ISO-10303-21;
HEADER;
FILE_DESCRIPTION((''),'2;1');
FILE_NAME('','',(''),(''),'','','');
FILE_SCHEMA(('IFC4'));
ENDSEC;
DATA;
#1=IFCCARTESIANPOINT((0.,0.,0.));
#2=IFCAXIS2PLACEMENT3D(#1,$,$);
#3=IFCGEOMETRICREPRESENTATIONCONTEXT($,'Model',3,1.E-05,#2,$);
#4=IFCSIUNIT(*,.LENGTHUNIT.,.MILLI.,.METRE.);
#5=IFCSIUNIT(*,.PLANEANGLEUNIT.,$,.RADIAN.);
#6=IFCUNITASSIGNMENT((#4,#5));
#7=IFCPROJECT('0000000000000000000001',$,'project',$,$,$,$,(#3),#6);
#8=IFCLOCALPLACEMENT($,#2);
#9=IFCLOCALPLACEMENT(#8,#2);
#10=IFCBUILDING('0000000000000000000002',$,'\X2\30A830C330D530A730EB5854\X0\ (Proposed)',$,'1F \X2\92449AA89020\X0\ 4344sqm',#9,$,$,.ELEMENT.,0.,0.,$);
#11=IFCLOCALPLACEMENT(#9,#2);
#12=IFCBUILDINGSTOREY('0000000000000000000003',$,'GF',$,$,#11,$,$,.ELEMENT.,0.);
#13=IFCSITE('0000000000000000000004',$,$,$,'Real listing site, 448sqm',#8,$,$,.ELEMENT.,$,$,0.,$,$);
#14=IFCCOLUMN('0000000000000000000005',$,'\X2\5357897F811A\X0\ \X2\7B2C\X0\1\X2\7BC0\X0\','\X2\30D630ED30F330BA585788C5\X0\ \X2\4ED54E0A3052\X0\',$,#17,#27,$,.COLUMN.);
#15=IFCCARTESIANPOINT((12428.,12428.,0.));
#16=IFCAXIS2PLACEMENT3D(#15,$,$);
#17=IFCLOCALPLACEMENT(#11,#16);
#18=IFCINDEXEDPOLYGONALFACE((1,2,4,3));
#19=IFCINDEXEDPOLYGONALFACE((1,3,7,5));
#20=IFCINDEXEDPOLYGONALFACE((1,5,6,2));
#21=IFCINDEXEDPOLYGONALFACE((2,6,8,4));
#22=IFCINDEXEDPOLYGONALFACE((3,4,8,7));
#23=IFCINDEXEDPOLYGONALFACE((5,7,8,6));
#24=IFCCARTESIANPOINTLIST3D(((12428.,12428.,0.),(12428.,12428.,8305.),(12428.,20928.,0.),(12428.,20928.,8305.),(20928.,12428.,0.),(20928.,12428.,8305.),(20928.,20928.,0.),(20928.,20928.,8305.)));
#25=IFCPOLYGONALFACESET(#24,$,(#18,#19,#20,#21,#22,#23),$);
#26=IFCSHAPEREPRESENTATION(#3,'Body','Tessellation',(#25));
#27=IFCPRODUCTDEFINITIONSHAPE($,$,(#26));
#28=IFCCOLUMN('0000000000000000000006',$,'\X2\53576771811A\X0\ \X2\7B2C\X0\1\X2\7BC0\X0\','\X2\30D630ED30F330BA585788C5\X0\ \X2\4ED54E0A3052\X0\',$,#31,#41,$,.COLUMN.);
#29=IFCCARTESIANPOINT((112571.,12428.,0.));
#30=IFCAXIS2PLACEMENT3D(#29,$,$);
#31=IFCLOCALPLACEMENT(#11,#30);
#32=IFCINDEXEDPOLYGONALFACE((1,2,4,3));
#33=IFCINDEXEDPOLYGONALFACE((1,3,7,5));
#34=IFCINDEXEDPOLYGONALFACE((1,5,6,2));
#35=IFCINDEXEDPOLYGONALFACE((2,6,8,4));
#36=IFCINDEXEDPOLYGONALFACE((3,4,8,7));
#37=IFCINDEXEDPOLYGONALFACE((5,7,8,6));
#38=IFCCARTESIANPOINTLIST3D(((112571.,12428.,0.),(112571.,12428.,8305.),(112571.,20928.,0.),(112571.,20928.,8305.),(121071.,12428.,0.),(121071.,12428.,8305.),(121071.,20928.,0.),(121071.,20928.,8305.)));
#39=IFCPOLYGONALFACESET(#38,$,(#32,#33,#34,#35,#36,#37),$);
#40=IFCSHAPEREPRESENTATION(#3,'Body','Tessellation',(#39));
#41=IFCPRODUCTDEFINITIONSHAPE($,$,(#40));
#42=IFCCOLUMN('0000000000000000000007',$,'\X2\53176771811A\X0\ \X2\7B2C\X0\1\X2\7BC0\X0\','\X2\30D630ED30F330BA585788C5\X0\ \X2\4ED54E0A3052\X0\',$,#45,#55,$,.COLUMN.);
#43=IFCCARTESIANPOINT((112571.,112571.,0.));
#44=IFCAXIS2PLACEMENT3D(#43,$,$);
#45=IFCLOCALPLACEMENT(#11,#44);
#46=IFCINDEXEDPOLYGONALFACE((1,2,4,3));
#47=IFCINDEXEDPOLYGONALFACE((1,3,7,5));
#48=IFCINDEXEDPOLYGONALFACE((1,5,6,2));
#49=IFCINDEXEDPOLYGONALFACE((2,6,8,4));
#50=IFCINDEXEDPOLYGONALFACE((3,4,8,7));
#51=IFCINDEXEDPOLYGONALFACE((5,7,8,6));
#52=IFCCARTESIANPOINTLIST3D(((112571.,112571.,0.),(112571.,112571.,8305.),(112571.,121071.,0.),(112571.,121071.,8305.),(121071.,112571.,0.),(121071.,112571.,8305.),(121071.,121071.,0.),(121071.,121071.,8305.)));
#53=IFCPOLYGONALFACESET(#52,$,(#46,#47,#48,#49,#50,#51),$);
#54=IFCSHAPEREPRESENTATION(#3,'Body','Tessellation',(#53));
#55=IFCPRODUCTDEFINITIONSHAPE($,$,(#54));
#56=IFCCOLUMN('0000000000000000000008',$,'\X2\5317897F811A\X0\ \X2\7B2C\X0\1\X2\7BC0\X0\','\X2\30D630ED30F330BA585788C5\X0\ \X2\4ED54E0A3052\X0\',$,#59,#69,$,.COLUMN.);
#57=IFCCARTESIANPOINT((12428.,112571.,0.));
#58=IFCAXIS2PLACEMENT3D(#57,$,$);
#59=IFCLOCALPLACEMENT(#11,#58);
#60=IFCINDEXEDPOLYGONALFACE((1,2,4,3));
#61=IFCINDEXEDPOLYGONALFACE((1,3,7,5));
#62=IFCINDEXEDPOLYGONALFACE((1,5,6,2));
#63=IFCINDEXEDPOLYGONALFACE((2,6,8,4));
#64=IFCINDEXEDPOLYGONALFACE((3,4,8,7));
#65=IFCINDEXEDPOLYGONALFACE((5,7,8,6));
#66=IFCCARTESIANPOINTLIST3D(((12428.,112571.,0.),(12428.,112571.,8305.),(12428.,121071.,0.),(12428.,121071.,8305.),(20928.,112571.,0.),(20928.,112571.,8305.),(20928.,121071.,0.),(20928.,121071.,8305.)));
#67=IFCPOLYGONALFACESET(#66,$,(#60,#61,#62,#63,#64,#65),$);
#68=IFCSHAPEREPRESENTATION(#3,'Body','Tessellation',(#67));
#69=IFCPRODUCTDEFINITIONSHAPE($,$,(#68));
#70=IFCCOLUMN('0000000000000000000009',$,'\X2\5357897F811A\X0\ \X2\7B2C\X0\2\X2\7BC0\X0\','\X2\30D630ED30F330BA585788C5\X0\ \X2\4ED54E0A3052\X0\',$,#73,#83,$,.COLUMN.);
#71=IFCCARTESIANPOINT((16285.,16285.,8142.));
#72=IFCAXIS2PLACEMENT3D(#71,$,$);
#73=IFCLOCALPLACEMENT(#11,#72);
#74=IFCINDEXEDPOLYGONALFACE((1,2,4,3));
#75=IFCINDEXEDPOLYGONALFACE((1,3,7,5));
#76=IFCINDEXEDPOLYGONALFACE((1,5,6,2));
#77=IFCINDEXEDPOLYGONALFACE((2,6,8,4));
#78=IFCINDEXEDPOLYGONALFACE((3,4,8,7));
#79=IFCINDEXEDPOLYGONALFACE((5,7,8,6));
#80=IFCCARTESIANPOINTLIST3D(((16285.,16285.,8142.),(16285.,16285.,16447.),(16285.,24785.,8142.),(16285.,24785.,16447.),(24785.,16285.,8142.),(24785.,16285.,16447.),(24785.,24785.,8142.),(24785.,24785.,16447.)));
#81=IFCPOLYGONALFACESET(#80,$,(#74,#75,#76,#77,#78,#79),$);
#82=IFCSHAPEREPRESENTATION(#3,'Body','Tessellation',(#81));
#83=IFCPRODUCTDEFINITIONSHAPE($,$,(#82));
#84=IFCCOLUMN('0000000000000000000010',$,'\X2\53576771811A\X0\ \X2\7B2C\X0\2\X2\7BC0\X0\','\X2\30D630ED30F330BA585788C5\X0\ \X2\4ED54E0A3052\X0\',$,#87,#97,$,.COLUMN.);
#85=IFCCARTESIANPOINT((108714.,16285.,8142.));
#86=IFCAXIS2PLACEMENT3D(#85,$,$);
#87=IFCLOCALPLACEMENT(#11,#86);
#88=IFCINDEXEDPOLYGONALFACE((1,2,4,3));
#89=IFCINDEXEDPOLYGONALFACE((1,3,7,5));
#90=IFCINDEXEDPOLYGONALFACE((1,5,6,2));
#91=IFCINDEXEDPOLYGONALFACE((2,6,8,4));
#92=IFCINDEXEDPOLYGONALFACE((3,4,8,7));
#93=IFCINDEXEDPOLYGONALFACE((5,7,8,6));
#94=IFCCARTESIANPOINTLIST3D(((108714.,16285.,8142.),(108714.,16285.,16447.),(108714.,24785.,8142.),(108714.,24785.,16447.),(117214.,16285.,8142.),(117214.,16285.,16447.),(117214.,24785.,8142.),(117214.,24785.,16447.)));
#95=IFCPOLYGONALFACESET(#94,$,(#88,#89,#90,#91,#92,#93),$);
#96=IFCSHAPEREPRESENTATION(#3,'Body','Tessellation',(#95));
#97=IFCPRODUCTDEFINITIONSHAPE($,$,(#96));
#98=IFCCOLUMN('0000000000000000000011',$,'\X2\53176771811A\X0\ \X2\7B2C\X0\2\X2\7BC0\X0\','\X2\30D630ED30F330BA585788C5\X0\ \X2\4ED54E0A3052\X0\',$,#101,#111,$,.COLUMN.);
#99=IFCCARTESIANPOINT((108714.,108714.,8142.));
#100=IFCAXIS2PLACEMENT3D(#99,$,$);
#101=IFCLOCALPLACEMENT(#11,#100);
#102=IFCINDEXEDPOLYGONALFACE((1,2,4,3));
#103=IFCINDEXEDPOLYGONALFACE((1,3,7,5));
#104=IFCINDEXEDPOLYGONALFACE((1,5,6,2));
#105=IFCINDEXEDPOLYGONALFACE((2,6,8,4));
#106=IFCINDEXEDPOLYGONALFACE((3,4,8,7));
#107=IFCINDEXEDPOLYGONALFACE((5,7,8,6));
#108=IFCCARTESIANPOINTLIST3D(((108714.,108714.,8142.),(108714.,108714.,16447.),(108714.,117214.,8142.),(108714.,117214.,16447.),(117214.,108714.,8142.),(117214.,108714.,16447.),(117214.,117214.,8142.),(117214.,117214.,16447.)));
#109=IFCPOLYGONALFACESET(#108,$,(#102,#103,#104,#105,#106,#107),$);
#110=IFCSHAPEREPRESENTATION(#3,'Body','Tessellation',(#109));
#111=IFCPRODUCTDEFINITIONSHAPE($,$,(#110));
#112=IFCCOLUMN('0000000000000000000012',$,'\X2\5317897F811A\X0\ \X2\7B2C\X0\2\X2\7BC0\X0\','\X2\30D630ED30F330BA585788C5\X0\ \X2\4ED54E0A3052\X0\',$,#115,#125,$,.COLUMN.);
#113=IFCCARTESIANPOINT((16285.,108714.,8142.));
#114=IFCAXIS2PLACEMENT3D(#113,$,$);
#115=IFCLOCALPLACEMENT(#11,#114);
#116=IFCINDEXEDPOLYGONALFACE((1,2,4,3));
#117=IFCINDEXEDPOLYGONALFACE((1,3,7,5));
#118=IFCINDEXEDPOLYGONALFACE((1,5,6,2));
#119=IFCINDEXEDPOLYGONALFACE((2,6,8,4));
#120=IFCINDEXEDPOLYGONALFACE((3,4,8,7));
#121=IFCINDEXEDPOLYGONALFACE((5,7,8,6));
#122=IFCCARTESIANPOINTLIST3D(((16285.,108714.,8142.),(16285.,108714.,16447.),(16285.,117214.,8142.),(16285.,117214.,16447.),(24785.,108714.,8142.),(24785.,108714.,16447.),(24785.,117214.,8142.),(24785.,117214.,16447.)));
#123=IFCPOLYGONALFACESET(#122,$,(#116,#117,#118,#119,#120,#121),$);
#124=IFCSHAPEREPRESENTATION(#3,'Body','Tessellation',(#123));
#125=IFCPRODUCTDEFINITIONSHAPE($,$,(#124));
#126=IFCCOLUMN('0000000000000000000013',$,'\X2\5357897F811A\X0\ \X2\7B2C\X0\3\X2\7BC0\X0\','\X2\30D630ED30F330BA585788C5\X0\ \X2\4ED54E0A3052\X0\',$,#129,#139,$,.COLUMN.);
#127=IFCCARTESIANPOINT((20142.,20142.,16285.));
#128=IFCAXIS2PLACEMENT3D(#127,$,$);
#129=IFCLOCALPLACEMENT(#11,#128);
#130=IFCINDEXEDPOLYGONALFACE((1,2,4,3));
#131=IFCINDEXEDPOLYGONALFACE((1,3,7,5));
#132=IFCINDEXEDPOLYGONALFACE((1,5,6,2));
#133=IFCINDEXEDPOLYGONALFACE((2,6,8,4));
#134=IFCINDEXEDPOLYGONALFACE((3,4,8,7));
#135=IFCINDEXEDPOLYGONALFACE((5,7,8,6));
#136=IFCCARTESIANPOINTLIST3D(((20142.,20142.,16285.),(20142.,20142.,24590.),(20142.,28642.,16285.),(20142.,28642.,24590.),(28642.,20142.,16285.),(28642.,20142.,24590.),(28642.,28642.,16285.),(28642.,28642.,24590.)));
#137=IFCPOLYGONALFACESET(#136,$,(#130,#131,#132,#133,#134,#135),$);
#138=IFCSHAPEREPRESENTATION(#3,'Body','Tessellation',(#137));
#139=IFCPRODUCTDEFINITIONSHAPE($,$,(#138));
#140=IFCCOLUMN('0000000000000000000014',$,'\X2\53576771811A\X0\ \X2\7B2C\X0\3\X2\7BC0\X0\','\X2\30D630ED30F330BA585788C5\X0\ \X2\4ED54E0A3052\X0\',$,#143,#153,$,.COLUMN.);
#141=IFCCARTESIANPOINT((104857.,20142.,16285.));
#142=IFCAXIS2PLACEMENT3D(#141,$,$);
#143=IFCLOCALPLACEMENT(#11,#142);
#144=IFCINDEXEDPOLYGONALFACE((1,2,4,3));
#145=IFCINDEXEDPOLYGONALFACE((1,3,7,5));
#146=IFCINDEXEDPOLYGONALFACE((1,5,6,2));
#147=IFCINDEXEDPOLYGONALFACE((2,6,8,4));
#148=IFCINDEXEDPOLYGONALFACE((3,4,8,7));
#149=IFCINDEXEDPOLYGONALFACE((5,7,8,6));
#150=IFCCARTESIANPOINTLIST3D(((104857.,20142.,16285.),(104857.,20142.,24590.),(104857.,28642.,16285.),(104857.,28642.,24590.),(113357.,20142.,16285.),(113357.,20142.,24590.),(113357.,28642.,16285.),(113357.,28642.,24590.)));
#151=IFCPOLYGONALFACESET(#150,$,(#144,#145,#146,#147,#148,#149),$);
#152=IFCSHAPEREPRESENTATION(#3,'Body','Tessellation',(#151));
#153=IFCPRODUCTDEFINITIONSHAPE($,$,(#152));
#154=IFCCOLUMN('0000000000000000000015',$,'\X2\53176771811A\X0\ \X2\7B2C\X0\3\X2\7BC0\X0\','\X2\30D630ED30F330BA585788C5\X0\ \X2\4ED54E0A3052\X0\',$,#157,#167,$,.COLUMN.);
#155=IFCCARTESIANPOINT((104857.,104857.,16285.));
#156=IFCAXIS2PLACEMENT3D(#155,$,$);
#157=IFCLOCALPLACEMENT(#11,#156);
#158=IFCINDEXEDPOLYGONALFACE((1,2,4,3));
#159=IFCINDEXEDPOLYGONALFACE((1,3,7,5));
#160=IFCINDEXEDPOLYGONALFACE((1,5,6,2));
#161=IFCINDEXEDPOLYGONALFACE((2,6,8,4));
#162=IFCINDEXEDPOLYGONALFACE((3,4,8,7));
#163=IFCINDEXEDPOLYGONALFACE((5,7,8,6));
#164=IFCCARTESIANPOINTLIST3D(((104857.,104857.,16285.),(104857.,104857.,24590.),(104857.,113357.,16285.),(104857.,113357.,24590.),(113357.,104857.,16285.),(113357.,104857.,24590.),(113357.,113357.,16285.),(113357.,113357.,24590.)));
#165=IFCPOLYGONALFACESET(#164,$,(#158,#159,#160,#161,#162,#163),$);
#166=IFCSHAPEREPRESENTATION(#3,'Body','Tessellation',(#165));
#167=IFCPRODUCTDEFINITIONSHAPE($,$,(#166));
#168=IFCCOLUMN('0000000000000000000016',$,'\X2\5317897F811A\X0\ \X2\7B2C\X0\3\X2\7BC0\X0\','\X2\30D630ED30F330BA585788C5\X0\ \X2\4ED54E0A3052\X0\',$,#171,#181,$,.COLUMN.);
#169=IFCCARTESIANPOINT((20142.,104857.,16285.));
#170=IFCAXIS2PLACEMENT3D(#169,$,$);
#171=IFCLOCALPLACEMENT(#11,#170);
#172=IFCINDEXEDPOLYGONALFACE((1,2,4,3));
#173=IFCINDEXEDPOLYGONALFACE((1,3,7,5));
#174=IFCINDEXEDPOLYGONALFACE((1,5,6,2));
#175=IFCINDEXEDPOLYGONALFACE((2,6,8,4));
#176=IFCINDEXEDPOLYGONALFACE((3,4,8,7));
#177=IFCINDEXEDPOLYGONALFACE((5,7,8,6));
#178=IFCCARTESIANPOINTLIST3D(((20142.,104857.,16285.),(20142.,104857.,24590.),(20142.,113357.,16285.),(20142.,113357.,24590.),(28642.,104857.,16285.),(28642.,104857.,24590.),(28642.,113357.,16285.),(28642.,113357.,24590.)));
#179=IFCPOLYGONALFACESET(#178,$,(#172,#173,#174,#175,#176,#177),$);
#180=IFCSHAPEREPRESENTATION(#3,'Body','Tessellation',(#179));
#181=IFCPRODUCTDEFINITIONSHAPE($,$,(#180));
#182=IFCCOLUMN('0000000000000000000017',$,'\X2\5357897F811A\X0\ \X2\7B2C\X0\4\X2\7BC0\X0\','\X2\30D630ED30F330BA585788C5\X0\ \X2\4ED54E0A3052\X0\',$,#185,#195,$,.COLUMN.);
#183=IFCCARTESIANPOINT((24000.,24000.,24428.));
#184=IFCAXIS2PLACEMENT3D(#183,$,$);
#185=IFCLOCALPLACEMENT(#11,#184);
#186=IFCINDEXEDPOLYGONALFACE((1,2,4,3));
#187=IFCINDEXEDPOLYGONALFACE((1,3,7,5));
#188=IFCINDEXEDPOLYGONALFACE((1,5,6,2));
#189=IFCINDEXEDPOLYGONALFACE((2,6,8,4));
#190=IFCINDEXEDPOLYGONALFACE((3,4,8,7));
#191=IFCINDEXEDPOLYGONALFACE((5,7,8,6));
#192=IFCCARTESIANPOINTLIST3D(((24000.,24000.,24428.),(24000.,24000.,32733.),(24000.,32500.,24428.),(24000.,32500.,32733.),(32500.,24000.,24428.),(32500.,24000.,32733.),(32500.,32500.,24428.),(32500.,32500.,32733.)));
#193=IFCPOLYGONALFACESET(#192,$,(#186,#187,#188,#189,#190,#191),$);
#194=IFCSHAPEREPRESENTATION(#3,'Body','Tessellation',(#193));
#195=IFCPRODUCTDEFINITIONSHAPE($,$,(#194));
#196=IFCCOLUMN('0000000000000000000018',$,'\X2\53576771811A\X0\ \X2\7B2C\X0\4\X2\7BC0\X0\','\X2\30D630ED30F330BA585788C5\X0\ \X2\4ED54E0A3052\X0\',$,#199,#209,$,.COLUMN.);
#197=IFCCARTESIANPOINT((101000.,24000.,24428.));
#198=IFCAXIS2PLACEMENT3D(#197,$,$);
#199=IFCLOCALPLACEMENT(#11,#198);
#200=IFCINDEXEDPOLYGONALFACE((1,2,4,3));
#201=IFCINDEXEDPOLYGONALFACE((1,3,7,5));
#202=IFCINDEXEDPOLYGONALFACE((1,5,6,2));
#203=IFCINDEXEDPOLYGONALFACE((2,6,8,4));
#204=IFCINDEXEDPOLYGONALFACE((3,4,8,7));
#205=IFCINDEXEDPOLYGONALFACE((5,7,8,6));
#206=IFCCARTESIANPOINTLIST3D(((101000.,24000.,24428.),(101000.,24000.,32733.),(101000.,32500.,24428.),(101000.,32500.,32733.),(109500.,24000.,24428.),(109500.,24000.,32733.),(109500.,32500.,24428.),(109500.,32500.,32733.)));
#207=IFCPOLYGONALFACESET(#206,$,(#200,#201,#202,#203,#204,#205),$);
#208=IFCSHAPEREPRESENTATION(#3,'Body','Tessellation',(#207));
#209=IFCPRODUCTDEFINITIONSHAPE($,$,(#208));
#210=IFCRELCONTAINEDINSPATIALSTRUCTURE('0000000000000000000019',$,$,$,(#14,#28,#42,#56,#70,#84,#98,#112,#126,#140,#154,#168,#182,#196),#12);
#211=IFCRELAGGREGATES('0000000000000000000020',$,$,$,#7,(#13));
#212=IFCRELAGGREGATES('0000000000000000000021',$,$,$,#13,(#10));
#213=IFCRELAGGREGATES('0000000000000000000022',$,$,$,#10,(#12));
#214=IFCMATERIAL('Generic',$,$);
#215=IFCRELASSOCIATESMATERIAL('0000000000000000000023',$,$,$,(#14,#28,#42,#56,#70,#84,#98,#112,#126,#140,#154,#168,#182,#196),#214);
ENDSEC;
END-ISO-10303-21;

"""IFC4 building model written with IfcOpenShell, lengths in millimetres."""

from ifc_helpers import new_model, si_unit, frame, frame_2d, origin, place, context, project, spatial, rectangle, extrude, material, element, save


model = new_model("IFC4")

# Units and contexts
model_context = context("Model", 3, precision=1e-05, world=origin())
ifc_project = project(units=[si_unit("LENGTHUNIT", "METRE", prefix="MILLI"), si_unit("PLANEANGLEUNIT", "RADIAN")], contexts=[model_context])

# Site, building, storey
site_placement = place(None, origin())
site = spatial("IfcSite", under=ifc_project, at=site_placement, ObjectType="Real listing site, 448sqm", CompositionType="ELEMENT", RefElevation=0.0)
building_placement = place(site_placement, origin())
building = spatial("IfcBuilding", under=site, at=building_placement, Name="エッフェル塔 (Proposed)", ObjectType="1F 鉄骨造 4344sqm", CompositionType="ELEMENT", ElevationOfRefHeight=0.0, ElevationOfTerrain=0.0)
storey_placement = place(building_placement, origin())
storey = spatial("IfcBuildingStorey", under=building, at=storey_placement, Name="GF", CompositionType="ELEMENT", Elevation=0.0)

# Columns
ifc_material = material(Name="Generic")
column_1_placement = place(storey_placement, frame((12428.0, 12428.0, 0.0)))
element("IfcColumn", 1, at=column_1_placement, inside=storey, material=ifc_material, Name="南西脚 第1節", Description="ブロンズ塗装 仕上げ", PredefinedType="COLUMN", context=model_context, shape_type="SweptSolid", body=[
    extrude(rectangle(XDim=8500.0, YDim=8500.0, at=frame_2d((4250.0, 4250.0))), frame((12428.0, 12428.0, 0.0)), (0.0, 0.0, 1.0), 8305.0),
])
column_2_placement = place(storey_placement, frame((112571.0, 12428.0, 0.0)))
element("IfcColumn", 2, at=column_2_placement, inside=storey, material=ifc_material, Name="南東脚 第1節", Description="ブロンズ塗装 仕上げ", PredefinedType="COLUMN", context=model_context, shape_type="SweptSolid", body=[
    extrude(rectangle(XDim=8500.0, YDim=8500.0, at=frame_2d((4250.0, 4250.0))), frame((112571.0, 12428.0, 0.0)), (0.0, 0.0, 1.0), 8305.0),
])
column_3_placement = place(storey_placement, frame((112571.0, 112571.0, 0.0)))
element("IfcColumn", 3, at=column_3_placement, inside=storey, material=ifc_material, Name="北東脚 第1節", Description="ブロンズ塗装 仕上げ", PredefinedType="COLUMN", context=model_context, shape_type="SweptSolid", body=[
    extrude(rectangle(XDim=8500.0, YDim=8500.0, at=frame_2d((4250.0, 4250.0))), frame((112571.0, 112571.0, 0.0)), (0.0, 0.0, 1.0), 8305.0),
])
column_4_placement = place(storey_placement, frame((12428.0, 112571.0, 0.0)))
element("IfcColumn", 4, at=column_4_placement, inside=storey, material=ifc_material, Name="北西脚 第1節", Description="ブロンズ塗装 仕上げ", PredefinedType="COLUMN", context=model_context, shape_type="SweptSolid", body=[
    extrude(rectangle(XDim=8500.0, YDim=8500.0, at=frame_2d((4250.0, 4250.0))), frame((12428.0, 112571.0, 0.0)), (0.0, 0.0, 1.0), 8305.0),
])
column_5_placement = place(storey_placement, frame((16285.0, 16285.0, 8142.0)))
element("IfcColumn", 5, at=column_5_placement, inside=storey, material=ifc_material, Name="南西脚 第2節", Description="ブロンズ塗装 仕上げ", PredefinedType="COLUMN", context=model_context, shape_type="SweptSolid", body=[
    extrude(rectangle(XDim=8500.0, YDim=8500.0, at=frame_2d((4250.0, 4250.0))), frame((16285.0, 16285.0, 8142.0)), (0.0, 0.0, 1.0), 8305.0),
])
column_6_placement = place(storey_placement, frame((108714.0, 16285.0, 8142.0)))
element("IfcColumn", 6, at=column_6_placement, inside=storey, material=ifc_material, Name="南東脚 第2節", Description="ブロンズ塗装 仕上げ", PredefinedType="COLUMN", context=model_context, shape_type="SweptSolid", body=[
    extrude(rectangle(XDim=8500.0, YDim=8500.0, at=frame_2d((4250.0, 4250.0))), frame((108714.0, 16285.0, 8142.0)), (0.0, 0.0, 1.0), 8305.0),
])
column_7_placement = place(storey_placement, frame((108714.0, 108714.0, 8142.0)))
element("IfcColumn", 7, at=column_7_placement, inside=storey, material=ifc_material, Name="北東脚 第2節", Description="ブロンズ塗装 仕上げ", PredefinedType="COLUMN", context=model_context, shape_type="SweptSolid", body=[
    extrude(rectangle(XDim=8500.0, YDim=8500.0, at=frame_2d((4250.0, 4250.0))), frame((108714.0, 108714.0, 8142.0)), (0.0, 0.0, 1.0), 8305.0),
])
column_8_placement = place(storey_placement, frame((16285.0, 108714.0, 8142.0)))
element("IfcColumn", 8, at=column_8_placement, inside=storey, material=ifc_material, Name="北西脚 第2節", Description="ブロンズ塗装 仕上げ", PredefinedType="COLUMN", context=model_context, shape_type="SweptSolid", body=[
    extrude(rectangle(XDim=8500.0, YDim=8500.0, at=frame_2d((4250.0, 4250.0))), frame((16285.0, 108714.0, 8142.0)), (0.0, 0.0, 1.0), 8305.0),
])
column_9_placement = place(storey_placement, frame((20142.0, 20142.0, 16285.0)))
element("IfcColumn", 9, at=column_9_placement, inside=storey, material=ifc_material, Name="南西脚 第3節", Description="ブロンズ塗装 仕上げ", PredefinedType="COLUMN", context=model_context, shape_type="SweptSolid", body=[
    extrude(rectangle(XDim=8500.0, YDim=8500.0, at=frame_2d((4250.0, 4250.0))), frame((20142.0, 20142.0, 16285.0)), (0.0, 0.0, 1.0), 8305.0),
])
column_10_placement = place(storey_placement, frame((104857.0, 20142.0, 16285.0)))
element("IfcColumn", 10, at=column_10_placement, inside=storey, material=ifc_material, Name="南東脚 第3節", Description="ブロンズ塗装 仕上げ", PredefinedType="COLUMN", context=model_context, shape_type="SweptSolid", body=[
    extrude(rectangle(XDim=8500.0, YDim=8500.0, at=frame_2d((4250.0, 4250.0))), frame((104857.0, 20142.0, 16285.0)), (0.0, 0.0, 1.0), 8305.0),
])
column_11_placement = place(storey_placement, frame((104857.0, 104857.0, 16285.0)))
element("IfcColumn", 11, at=column_11_placement, inside=storey, material=ifc_material, Name="北東脚 第3節", Description="ブロンズ塗装 仕上げ", PredefinedType="COLUMN", context=model_context, shape_type="SweptSolid", body=[
    extrude(rectangle(XDim=8500.0, YDim=8500.0, at=frame_2d((4250.0, 4250.0))), frame((104857.0, 104857.0, 16285.0)), (0.0, 0.0, 1.0), 8305.0),
])
column_12_placement = place(storey_placement, frame((20142.0, 104857.0, 16285.0)))
element("IfcColumn", 12, at=column_12_placement, inside=storey, material=ifc_material, Name="北西脚 第3節", Description="ブロンズ塗装 仕上げ", PredefinedType="COLUMN", context=model_context, shape_type="SweptSolid", body=[
    extrude(rectangle(XDim=8500.0, YDim=8500.0, at=frame_2d((4250.0, 4250.0))), frame((20142.0, 104857.0, 16285.0)), (0.0, 0.0, 1.0), 8305.0),
])
column_13_placement = place(storey_placement, frame((24000.0, 24000.0, 24428.0)))
element("IfcColumn", 13, at=column_13_placement, inside=storey, material=ifc_material, Name="南西脚 第4節", Description="ブロンズ塗装 仕上げ", PredefinedType="COLUMN", context=model_context, shape_type="SweptSolid", body=[
    extrude(rectangle(XDim=8500.0, YDim=8500.0, at=frame_2d((4250.0, 4250.0))), frame((24000.0, 24000.0, 24428.0)), (0.0, 0.0, 1.0), 8305.0),
])
column_14_placement = place(storey_placement, frame((101000.0, 24000.0, 24428.0)))
element("IfcColumn", 14, at=column_14_placement, inside=storey, material=ifc_material, Name="南東脚 第4節", Description="ブロンズ塗装 仕上げ", PredefinedType="COLUMN", context=model_context, shape_type="SweptSolid", body=[
    extrude(rectangle(XDim=8500.0, YDim=8500.0, at=frame_2d((4250.0, 4250.0))), frame((101000.0, 24000.0, 24428.0)), (0.0, 0.0, 1.0), 8305.0),
])

save(model, "model.ifc")
